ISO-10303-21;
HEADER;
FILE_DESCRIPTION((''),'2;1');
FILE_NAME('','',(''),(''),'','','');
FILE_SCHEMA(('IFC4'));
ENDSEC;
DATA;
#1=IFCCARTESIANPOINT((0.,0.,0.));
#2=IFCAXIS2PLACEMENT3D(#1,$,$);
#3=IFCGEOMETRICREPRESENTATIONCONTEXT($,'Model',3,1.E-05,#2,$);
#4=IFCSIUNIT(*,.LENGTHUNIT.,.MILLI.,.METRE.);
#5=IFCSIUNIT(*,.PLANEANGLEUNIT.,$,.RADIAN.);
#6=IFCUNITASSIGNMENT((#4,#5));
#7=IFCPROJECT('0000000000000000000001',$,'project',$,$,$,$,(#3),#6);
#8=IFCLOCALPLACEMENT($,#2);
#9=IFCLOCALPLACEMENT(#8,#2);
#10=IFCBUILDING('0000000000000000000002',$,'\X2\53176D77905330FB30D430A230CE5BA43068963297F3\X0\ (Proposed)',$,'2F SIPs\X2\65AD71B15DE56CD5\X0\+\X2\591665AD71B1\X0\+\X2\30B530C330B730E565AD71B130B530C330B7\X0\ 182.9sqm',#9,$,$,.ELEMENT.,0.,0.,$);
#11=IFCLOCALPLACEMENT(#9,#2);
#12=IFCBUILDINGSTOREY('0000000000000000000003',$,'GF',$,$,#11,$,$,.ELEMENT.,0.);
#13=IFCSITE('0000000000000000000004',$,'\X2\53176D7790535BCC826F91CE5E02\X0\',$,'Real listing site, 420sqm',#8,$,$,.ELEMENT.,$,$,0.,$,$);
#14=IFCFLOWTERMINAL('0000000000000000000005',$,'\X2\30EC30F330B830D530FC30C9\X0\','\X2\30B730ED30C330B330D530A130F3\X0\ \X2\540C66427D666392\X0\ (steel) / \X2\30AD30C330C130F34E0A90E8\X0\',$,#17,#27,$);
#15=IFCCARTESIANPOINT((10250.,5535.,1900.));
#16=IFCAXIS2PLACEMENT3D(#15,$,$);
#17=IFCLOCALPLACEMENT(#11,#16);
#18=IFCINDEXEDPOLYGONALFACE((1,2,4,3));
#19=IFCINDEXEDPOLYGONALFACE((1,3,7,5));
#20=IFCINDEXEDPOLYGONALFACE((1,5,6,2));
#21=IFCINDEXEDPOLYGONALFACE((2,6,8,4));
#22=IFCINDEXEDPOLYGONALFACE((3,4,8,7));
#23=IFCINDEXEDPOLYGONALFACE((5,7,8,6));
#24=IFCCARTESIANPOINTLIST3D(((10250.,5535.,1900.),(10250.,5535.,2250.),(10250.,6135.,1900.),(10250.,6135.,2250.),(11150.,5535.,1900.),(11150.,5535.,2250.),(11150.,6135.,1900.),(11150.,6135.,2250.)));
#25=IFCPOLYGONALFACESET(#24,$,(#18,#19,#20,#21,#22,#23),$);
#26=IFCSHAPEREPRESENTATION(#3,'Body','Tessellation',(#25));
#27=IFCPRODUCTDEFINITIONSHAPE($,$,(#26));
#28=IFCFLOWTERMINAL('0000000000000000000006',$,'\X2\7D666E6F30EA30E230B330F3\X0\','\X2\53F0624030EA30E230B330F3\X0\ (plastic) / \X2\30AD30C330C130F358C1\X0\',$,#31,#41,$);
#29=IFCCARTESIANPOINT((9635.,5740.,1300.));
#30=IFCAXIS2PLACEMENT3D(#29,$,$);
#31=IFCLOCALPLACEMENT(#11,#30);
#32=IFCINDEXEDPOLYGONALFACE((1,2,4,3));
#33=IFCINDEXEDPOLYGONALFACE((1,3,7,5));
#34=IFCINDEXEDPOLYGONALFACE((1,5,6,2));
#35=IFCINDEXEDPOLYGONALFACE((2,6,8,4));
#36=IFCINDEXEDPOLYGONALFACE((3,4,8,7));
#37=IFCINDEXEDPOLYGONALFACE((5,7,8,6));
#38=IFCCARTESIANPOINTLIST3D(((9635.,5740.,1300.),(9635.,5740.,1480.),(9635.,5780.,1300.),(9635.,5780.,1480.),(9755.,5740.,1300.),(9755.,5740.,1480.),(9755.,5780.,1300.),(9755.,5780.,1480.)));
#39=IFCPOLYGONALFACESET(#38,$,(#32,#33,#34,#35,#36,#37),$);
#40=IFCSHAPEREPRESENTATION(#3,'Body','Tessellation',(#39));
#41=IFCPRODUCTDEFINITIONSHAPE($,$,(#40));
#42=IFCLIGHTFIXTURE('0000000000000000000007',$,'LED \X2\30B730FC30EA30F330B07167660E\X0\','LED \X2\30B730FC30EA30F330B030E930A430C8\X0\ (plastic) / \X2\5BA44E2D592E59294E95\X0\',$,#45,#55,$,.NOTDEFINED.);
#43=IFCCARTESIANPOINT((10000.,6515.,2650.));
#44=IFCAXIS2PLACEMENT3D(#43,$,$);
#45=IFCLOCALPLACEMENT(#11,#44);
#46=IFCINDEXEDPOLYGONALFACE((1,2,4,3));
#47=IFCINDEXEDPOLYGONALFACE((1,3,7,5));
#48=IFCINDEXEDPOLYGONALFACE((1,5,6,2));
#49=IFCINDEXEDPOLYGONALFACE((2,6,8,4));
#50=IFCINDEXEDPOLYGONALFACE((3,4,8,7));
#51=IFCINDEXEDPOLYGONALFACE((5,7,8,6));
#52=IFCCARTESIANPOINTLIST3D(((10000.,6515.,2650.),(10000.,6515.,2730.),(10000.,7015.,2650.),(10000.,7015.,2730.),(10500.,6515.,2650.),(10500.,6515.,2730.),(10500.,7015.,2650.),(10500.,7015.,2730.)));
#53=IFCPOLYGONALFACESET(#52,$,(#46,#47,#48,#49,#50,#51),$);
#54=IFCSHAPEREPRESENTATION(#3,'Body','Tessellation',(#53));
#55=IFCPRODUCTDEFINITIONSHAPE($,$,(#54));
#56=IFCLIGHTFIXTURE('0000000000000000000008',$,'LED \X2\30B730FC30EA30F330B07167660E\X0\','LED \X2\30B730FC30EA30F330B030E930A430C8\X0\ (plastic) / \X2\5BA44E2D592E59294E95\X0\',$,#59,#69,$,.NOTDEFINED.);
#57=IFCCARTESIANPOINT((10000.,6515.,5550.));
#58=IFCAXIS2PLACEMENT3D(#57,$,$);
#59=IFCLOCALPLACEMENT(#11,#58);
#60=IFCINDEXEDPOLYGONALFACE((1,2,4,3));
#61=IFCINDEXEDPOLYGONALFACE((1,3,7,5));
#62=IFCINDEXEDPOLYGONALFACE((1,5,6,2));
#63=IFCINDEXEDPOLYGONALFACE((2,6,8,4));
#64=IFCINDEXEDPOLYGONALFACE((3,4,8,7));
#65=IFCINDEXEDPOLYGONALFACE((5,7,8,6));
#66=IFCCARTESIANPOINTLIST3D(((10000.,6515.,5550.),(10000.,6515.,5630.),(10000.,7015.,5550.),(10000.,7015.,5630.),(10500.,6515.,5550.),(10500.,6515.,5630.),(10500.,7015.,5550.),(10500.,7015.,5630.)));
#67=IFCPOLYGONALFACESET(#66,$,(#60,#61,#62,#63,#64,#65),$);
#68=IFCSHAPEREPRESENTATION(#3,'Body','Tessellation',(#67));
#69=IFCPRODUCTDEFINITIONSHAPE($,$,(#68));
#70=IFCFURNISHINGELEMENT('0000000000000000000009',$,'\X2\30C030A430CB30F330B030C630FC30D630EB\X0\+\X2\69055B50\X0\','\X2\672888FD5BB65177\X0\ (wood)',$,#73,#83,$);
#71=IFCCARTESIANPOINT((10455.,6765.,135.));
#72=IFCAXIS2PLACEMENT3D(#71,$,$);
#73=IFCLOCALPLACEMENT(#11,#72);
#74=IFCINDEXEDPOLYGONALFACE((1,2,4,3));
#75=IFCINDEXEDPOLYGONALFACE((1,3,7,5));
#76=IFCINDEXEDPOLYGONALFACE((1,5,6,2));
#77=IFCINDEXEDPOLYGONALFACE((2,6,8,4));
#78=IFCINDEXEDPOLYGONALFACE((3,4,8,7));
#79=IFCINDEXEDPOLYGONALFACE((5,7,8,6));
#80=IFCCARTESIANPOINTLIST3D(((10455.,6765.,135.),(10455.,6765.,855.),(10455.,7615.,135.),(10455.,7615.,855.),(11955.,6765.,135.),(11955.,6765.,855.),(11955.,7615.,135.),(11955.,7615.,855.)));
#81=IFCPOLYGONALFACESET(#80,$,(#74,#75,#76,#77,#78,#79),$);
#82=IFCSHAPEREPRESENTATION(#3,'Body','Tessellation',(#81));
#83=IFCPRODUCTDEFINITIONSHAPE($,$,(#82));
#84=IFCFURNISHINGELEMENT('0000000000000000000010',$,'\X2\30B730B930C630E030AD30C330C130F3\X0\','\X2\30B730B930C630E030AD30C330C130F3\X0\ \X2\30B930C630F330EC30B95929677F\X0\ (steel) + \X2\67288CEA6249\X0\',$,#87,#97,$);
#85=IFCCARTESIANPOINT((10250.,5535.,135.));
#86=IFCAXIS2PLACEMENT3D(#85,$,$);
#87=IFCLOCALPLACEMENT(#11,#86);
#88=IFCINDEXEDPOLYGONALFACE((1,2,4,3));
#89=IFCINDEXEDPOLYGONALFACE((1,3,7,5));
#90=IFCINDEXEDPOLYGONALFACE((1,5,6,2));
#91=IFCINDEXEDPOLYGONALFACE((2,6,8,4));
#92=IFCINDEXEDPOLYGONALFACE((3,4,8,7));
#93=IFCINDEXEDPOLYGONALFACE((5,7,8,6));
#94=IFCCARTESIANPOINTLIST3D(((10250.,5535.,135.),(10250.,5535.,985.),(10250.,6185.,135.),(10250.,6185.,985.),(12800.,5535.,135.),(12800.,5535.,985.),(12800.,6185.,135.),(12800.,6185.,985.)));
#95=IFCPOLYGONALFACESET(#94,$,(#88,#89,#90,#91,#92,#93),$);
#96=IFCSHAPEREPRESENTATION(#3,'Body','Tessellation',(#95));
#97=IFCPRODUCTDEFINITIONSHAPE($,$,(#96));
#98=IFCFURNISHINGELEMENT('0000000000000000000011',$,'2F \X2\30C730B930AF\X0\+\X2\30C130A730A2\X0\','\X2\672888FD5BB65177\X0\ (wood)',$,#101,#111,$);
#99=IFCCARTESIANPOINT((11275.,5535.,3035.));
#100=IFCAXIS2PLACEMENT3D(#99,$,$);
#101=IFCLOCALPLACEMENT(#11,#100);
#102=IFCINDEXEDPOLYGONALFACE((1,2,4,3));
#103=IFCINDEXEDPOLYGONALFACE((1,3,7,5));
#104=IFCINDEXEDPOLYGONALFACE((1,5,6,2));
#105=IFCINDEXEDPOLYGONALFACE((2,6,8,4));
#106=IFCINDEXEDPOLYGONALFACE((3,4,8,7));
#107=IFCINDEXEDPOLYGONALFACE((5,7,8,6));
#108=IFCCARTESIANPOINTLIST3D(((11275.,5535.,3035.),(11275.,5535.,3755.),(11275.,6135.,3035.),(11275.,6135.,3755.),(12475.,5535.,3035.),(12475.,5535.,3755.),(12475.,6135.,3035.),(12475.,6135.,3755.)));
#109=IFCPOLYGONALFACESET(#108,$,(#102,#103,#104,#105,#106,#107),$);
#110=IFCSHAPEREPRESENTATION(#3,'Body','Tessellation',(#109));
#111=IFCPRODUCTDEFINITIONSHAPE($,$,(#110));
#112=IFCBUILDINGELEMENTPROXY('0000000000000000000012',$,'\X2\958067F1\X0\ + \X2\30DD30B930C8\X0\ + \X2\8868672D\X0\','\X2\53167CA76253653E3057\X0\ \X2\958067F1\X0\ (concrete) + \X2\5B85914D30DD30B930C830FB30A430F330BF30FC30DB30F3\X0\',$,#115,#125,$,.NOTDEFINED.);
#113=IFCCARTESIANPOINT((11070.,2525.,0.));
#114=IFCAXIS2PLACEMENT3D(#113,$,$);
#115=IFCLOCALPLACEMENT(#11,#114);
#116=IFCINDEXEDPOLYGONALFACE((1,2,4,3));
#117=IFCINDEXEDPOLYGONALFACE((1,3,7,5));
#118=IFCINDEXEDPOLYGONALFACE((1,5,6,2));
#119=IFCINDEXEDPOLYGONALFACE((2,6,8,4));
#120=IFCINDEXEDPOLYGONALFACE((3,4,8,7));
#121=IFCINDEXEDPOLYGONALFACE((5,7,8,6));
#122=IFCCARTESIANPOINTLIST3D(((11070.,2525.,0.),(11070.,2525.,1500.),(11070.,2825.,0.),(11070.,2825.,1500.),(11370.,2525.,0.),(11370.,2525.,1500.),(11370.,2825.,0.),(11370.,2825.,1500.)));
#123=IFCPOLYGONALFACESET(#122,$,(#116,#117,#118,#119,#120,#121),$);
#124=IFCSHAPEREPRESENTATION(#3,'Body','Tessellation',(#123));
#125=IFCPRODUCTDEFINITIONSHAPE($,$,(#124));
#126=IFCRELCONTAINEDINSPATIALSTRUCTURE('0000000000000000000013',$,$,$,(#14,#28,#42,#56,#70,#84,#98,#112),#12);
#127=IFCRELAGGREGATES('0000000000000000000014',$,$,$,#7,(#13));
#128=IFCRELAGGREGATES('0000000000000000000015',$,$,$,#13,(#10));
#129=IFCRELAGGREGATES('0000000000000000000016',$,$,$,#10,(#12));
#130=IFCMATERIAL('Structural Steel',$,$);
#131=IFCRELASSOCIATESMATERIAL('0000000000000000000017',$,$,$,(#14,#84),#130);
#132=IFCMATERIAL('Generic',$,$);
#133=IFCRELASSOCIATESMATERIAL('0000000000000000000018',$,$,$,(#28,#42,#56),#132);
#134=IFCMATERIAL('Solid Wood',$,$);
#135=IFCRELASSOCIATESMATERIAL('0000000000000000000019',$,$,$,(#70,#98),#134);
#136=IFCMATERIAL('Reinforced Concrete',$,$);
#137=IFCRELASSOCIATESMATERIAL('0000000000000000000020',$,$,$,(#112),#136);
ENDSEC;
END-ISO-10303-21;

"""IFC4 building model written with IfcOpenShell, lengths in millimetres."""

from ifc_helpers import new_model, si_unit, frame, frame_2d, origin, place, context, project, spatial, rectangle, extrude, material, element, save


model = new_model("IFC4")

# Units and contexts
model_context = context("Model", 3, precision=1e-05, world=origin())
ifc_project = project(units=[si_unit("LENGTHUNIT", "METRE", prefix="MILLI"), si_unit("PLANEANGLEUNIT", "RADIAN")], contexts=[model_context])

# Site, building, storey
site_placement = place(None, origin())
site = spatial("IfcSite", under=ifc_project, at=site_placement, Name="北海道富良野市", ObjectType="Real listing site, 420sqm", CompositionType="ELEMENT", RefElevation=0.0)
building_placement = place(site_placement, origin())
building = spatial("IfcBuilding", under=site, at=building_placement, Name="北海道・ピアノ室と防音 (Proposed)", ObjectType="2F SIPs断熱工法+外断熱+サッシュ断熱サッシ 182.9sqm", CompositionType="ELEMENT", ElevationOfRefHeight=0.0, ElevationOfTerrain=0.0)
storey_placement = place(building_placement, origin())
storey = spatial("IfcBuildingStorey", under=building, at=storey_placement, Name="GF", CompositionType="ELEMENT", Elevation=0.0)

# Shared definitions
ifc_material_1 = material(Name="Solid Wood")

# Shared definitions
ifc_material_2 = material(Name="Structural Steel")

# Shared definitions
ifc_material_3 = material(Name="Reinforced Concrete")

# Flow terminals
flow_terminal_1_placement = place(storey_placement, frame((10250.0, 5535.0, 1900.0)))
element("IfcFlowTerminal", 1, at=flow_terminal_1_placement, inside=storey, material=ifc_material_2, Name="レンジフード", Description="シロッコファン 同時給排 (steel) / キッチン上部", context=model_context, shape_type="SweptSolid", body=[
    extrude(rectangle(XDim=900.0, YDim=600.0, at=frame_2d((450.0, 300.0))), frame((10250.0, 5535.0, 1900.0)), (0.0, 0.0, 1.0), 350.0),
])
ifc_material_4 = material(Name="Generic")
flow_terminal_2_placement = place(storey_placement, frame((9635.0, 5740.0, 1300.0)))
element("IfcFlowTerminal", 2, at=flow_terminal_2_placement, inside=storey, material=ifc_material_4, Name="給湯リモコン", Description="台所リモコン (plastic) / キッチン壁", context=model_context, shape_type="SweptSolid", body=[
    extrude(rectangle(XDim=120.0, YDim=40.0, at=frame_2d((60.0, 20.0))), frame((9635.0, 5740.0, 1300.0)), (0.0, 0.0, 1.0), 180.0),
])

# Light fixtures
light_fixture_1_placement = place(storey_placement, frame((10000.0, 6515.0, 2650.0)))
element("IfcLightFixture", 3, at=light_fixture_1_placement, inside=storey, material=ifc_material_4, Name="LED シーリング照明", Description="LED シーリングライト (plastic) / 室中央天井", PredefinedType="NOTDEFINED", context=model_context, shape_type="SweptSolid", body=[
    extrude(rectangle(XDim=500.0, YDim=500.0, at=frame_2d((250.0, 250.0))), frame((10000.0, 6515.0, 2650.0)), (0.0, 0.0, 1.0), 80.0),
])
light_fixture_2_placement = place(storey_placement, frame((10000.0, 6515.0, 5550.0)))
element("IfcLightFixture", 4, at=light_fixture_2_placement, inside=storey, material=ifc_material_4, Name="LED シーリング照明", Description="LED シーリングライト (plastic) / 室中央天井", PredefinedType="NOTDEFINED", context=model_context, shape_type="SweptSolid", body=[
    extrude(rectangle(XDim=500.0, YDim=500.0, at=frame_2d((250.0, 250.0))), frame((10000.0, 6515.0, 5550.0)), (0.0, 0.0, 1.0), 80.0),
])

# Furnishing elements
furnishing_1_placement = place(storey_placement, frame((10455.0, 6765.0, 135.0)))
element("IfcFurnishingElement", 5, at=furnishing_1_placement, inside=storey, material=ifc_material_1, Name="ダイニングテーブル+椅子", Description="木製家具 (wood)", context=model_context, shape_type="SweptSolid", body=[
    extrude(rectangle(XDim=1500.0, YDim=850.0, at=frame_2d((750.0, 425.0))), frame((10455.0, 6765.0, 135.0)), (0.0, 0.0, 1.0), 720.0),
])
furnishing_2_placement = place(storey_placement, frame((10250.0, 5535.0, 135.0)))
element("IfcFurnishingElement", 6, at=furnishing_2_placement, inside=storey, material=ifc_material_2, Name="システムキッチン", Description="システムキッチン ステンレス天板 (steel) + 木質扉", context=model_context, shape_type="SweptSolid", body=[
    extrude(rectangle(XDim=2550.0, YDim=650.0, at=frame_2d((1275.0, 325.0))), frame((10250.0, 5535.0, 135.0)), (0.0, 0.0, 1.0), 850.0),
])
furnishing_3_placement = place(storey_placement, frame((11275.0, 5535.0, 3035.0)))
element("IfcFurnishingElement", 7, at=furnishing_3_placement, inside=storey, material=ifc_material_1, Name="2F デスク+チェア", Description="木製家具 (wood)", context=model_context, shape_type="SweptSolid", body=[
    extrude(rectangle(XDim=1200.0, YDim=600.0, at=frame_2d((600.0, 300.0))), frame((11275.0, 5535.0, 3035.0)), (0.0, 0.0, 1.0), 720.0),
])

# Building element proxy
proxy_placement = place(storey_placement, frame((11070.0, 2525.0, 0.0)))
element("IfcBuildingElementProxy", 8, at=proxy_placement, inside=storey, material=ifc_material_3, Name="門柱 + ポスト + 表札", Description="化粧打放し 門柱 (concrete) + 宅配ポスト・インターホン", PredefinedType="NOTDEFINED", context=model_context, shape_type="SweptSolid", body=[
    extrude(rectangle(XDim=300.0, YDim=300.0, at=frame_2d((150.0, 150.0))), frame((11070.0, 2525.0, 0.0)), (0.0, 0.0, 1.0), 1500.0),
])

save(model, "model.ifc")
